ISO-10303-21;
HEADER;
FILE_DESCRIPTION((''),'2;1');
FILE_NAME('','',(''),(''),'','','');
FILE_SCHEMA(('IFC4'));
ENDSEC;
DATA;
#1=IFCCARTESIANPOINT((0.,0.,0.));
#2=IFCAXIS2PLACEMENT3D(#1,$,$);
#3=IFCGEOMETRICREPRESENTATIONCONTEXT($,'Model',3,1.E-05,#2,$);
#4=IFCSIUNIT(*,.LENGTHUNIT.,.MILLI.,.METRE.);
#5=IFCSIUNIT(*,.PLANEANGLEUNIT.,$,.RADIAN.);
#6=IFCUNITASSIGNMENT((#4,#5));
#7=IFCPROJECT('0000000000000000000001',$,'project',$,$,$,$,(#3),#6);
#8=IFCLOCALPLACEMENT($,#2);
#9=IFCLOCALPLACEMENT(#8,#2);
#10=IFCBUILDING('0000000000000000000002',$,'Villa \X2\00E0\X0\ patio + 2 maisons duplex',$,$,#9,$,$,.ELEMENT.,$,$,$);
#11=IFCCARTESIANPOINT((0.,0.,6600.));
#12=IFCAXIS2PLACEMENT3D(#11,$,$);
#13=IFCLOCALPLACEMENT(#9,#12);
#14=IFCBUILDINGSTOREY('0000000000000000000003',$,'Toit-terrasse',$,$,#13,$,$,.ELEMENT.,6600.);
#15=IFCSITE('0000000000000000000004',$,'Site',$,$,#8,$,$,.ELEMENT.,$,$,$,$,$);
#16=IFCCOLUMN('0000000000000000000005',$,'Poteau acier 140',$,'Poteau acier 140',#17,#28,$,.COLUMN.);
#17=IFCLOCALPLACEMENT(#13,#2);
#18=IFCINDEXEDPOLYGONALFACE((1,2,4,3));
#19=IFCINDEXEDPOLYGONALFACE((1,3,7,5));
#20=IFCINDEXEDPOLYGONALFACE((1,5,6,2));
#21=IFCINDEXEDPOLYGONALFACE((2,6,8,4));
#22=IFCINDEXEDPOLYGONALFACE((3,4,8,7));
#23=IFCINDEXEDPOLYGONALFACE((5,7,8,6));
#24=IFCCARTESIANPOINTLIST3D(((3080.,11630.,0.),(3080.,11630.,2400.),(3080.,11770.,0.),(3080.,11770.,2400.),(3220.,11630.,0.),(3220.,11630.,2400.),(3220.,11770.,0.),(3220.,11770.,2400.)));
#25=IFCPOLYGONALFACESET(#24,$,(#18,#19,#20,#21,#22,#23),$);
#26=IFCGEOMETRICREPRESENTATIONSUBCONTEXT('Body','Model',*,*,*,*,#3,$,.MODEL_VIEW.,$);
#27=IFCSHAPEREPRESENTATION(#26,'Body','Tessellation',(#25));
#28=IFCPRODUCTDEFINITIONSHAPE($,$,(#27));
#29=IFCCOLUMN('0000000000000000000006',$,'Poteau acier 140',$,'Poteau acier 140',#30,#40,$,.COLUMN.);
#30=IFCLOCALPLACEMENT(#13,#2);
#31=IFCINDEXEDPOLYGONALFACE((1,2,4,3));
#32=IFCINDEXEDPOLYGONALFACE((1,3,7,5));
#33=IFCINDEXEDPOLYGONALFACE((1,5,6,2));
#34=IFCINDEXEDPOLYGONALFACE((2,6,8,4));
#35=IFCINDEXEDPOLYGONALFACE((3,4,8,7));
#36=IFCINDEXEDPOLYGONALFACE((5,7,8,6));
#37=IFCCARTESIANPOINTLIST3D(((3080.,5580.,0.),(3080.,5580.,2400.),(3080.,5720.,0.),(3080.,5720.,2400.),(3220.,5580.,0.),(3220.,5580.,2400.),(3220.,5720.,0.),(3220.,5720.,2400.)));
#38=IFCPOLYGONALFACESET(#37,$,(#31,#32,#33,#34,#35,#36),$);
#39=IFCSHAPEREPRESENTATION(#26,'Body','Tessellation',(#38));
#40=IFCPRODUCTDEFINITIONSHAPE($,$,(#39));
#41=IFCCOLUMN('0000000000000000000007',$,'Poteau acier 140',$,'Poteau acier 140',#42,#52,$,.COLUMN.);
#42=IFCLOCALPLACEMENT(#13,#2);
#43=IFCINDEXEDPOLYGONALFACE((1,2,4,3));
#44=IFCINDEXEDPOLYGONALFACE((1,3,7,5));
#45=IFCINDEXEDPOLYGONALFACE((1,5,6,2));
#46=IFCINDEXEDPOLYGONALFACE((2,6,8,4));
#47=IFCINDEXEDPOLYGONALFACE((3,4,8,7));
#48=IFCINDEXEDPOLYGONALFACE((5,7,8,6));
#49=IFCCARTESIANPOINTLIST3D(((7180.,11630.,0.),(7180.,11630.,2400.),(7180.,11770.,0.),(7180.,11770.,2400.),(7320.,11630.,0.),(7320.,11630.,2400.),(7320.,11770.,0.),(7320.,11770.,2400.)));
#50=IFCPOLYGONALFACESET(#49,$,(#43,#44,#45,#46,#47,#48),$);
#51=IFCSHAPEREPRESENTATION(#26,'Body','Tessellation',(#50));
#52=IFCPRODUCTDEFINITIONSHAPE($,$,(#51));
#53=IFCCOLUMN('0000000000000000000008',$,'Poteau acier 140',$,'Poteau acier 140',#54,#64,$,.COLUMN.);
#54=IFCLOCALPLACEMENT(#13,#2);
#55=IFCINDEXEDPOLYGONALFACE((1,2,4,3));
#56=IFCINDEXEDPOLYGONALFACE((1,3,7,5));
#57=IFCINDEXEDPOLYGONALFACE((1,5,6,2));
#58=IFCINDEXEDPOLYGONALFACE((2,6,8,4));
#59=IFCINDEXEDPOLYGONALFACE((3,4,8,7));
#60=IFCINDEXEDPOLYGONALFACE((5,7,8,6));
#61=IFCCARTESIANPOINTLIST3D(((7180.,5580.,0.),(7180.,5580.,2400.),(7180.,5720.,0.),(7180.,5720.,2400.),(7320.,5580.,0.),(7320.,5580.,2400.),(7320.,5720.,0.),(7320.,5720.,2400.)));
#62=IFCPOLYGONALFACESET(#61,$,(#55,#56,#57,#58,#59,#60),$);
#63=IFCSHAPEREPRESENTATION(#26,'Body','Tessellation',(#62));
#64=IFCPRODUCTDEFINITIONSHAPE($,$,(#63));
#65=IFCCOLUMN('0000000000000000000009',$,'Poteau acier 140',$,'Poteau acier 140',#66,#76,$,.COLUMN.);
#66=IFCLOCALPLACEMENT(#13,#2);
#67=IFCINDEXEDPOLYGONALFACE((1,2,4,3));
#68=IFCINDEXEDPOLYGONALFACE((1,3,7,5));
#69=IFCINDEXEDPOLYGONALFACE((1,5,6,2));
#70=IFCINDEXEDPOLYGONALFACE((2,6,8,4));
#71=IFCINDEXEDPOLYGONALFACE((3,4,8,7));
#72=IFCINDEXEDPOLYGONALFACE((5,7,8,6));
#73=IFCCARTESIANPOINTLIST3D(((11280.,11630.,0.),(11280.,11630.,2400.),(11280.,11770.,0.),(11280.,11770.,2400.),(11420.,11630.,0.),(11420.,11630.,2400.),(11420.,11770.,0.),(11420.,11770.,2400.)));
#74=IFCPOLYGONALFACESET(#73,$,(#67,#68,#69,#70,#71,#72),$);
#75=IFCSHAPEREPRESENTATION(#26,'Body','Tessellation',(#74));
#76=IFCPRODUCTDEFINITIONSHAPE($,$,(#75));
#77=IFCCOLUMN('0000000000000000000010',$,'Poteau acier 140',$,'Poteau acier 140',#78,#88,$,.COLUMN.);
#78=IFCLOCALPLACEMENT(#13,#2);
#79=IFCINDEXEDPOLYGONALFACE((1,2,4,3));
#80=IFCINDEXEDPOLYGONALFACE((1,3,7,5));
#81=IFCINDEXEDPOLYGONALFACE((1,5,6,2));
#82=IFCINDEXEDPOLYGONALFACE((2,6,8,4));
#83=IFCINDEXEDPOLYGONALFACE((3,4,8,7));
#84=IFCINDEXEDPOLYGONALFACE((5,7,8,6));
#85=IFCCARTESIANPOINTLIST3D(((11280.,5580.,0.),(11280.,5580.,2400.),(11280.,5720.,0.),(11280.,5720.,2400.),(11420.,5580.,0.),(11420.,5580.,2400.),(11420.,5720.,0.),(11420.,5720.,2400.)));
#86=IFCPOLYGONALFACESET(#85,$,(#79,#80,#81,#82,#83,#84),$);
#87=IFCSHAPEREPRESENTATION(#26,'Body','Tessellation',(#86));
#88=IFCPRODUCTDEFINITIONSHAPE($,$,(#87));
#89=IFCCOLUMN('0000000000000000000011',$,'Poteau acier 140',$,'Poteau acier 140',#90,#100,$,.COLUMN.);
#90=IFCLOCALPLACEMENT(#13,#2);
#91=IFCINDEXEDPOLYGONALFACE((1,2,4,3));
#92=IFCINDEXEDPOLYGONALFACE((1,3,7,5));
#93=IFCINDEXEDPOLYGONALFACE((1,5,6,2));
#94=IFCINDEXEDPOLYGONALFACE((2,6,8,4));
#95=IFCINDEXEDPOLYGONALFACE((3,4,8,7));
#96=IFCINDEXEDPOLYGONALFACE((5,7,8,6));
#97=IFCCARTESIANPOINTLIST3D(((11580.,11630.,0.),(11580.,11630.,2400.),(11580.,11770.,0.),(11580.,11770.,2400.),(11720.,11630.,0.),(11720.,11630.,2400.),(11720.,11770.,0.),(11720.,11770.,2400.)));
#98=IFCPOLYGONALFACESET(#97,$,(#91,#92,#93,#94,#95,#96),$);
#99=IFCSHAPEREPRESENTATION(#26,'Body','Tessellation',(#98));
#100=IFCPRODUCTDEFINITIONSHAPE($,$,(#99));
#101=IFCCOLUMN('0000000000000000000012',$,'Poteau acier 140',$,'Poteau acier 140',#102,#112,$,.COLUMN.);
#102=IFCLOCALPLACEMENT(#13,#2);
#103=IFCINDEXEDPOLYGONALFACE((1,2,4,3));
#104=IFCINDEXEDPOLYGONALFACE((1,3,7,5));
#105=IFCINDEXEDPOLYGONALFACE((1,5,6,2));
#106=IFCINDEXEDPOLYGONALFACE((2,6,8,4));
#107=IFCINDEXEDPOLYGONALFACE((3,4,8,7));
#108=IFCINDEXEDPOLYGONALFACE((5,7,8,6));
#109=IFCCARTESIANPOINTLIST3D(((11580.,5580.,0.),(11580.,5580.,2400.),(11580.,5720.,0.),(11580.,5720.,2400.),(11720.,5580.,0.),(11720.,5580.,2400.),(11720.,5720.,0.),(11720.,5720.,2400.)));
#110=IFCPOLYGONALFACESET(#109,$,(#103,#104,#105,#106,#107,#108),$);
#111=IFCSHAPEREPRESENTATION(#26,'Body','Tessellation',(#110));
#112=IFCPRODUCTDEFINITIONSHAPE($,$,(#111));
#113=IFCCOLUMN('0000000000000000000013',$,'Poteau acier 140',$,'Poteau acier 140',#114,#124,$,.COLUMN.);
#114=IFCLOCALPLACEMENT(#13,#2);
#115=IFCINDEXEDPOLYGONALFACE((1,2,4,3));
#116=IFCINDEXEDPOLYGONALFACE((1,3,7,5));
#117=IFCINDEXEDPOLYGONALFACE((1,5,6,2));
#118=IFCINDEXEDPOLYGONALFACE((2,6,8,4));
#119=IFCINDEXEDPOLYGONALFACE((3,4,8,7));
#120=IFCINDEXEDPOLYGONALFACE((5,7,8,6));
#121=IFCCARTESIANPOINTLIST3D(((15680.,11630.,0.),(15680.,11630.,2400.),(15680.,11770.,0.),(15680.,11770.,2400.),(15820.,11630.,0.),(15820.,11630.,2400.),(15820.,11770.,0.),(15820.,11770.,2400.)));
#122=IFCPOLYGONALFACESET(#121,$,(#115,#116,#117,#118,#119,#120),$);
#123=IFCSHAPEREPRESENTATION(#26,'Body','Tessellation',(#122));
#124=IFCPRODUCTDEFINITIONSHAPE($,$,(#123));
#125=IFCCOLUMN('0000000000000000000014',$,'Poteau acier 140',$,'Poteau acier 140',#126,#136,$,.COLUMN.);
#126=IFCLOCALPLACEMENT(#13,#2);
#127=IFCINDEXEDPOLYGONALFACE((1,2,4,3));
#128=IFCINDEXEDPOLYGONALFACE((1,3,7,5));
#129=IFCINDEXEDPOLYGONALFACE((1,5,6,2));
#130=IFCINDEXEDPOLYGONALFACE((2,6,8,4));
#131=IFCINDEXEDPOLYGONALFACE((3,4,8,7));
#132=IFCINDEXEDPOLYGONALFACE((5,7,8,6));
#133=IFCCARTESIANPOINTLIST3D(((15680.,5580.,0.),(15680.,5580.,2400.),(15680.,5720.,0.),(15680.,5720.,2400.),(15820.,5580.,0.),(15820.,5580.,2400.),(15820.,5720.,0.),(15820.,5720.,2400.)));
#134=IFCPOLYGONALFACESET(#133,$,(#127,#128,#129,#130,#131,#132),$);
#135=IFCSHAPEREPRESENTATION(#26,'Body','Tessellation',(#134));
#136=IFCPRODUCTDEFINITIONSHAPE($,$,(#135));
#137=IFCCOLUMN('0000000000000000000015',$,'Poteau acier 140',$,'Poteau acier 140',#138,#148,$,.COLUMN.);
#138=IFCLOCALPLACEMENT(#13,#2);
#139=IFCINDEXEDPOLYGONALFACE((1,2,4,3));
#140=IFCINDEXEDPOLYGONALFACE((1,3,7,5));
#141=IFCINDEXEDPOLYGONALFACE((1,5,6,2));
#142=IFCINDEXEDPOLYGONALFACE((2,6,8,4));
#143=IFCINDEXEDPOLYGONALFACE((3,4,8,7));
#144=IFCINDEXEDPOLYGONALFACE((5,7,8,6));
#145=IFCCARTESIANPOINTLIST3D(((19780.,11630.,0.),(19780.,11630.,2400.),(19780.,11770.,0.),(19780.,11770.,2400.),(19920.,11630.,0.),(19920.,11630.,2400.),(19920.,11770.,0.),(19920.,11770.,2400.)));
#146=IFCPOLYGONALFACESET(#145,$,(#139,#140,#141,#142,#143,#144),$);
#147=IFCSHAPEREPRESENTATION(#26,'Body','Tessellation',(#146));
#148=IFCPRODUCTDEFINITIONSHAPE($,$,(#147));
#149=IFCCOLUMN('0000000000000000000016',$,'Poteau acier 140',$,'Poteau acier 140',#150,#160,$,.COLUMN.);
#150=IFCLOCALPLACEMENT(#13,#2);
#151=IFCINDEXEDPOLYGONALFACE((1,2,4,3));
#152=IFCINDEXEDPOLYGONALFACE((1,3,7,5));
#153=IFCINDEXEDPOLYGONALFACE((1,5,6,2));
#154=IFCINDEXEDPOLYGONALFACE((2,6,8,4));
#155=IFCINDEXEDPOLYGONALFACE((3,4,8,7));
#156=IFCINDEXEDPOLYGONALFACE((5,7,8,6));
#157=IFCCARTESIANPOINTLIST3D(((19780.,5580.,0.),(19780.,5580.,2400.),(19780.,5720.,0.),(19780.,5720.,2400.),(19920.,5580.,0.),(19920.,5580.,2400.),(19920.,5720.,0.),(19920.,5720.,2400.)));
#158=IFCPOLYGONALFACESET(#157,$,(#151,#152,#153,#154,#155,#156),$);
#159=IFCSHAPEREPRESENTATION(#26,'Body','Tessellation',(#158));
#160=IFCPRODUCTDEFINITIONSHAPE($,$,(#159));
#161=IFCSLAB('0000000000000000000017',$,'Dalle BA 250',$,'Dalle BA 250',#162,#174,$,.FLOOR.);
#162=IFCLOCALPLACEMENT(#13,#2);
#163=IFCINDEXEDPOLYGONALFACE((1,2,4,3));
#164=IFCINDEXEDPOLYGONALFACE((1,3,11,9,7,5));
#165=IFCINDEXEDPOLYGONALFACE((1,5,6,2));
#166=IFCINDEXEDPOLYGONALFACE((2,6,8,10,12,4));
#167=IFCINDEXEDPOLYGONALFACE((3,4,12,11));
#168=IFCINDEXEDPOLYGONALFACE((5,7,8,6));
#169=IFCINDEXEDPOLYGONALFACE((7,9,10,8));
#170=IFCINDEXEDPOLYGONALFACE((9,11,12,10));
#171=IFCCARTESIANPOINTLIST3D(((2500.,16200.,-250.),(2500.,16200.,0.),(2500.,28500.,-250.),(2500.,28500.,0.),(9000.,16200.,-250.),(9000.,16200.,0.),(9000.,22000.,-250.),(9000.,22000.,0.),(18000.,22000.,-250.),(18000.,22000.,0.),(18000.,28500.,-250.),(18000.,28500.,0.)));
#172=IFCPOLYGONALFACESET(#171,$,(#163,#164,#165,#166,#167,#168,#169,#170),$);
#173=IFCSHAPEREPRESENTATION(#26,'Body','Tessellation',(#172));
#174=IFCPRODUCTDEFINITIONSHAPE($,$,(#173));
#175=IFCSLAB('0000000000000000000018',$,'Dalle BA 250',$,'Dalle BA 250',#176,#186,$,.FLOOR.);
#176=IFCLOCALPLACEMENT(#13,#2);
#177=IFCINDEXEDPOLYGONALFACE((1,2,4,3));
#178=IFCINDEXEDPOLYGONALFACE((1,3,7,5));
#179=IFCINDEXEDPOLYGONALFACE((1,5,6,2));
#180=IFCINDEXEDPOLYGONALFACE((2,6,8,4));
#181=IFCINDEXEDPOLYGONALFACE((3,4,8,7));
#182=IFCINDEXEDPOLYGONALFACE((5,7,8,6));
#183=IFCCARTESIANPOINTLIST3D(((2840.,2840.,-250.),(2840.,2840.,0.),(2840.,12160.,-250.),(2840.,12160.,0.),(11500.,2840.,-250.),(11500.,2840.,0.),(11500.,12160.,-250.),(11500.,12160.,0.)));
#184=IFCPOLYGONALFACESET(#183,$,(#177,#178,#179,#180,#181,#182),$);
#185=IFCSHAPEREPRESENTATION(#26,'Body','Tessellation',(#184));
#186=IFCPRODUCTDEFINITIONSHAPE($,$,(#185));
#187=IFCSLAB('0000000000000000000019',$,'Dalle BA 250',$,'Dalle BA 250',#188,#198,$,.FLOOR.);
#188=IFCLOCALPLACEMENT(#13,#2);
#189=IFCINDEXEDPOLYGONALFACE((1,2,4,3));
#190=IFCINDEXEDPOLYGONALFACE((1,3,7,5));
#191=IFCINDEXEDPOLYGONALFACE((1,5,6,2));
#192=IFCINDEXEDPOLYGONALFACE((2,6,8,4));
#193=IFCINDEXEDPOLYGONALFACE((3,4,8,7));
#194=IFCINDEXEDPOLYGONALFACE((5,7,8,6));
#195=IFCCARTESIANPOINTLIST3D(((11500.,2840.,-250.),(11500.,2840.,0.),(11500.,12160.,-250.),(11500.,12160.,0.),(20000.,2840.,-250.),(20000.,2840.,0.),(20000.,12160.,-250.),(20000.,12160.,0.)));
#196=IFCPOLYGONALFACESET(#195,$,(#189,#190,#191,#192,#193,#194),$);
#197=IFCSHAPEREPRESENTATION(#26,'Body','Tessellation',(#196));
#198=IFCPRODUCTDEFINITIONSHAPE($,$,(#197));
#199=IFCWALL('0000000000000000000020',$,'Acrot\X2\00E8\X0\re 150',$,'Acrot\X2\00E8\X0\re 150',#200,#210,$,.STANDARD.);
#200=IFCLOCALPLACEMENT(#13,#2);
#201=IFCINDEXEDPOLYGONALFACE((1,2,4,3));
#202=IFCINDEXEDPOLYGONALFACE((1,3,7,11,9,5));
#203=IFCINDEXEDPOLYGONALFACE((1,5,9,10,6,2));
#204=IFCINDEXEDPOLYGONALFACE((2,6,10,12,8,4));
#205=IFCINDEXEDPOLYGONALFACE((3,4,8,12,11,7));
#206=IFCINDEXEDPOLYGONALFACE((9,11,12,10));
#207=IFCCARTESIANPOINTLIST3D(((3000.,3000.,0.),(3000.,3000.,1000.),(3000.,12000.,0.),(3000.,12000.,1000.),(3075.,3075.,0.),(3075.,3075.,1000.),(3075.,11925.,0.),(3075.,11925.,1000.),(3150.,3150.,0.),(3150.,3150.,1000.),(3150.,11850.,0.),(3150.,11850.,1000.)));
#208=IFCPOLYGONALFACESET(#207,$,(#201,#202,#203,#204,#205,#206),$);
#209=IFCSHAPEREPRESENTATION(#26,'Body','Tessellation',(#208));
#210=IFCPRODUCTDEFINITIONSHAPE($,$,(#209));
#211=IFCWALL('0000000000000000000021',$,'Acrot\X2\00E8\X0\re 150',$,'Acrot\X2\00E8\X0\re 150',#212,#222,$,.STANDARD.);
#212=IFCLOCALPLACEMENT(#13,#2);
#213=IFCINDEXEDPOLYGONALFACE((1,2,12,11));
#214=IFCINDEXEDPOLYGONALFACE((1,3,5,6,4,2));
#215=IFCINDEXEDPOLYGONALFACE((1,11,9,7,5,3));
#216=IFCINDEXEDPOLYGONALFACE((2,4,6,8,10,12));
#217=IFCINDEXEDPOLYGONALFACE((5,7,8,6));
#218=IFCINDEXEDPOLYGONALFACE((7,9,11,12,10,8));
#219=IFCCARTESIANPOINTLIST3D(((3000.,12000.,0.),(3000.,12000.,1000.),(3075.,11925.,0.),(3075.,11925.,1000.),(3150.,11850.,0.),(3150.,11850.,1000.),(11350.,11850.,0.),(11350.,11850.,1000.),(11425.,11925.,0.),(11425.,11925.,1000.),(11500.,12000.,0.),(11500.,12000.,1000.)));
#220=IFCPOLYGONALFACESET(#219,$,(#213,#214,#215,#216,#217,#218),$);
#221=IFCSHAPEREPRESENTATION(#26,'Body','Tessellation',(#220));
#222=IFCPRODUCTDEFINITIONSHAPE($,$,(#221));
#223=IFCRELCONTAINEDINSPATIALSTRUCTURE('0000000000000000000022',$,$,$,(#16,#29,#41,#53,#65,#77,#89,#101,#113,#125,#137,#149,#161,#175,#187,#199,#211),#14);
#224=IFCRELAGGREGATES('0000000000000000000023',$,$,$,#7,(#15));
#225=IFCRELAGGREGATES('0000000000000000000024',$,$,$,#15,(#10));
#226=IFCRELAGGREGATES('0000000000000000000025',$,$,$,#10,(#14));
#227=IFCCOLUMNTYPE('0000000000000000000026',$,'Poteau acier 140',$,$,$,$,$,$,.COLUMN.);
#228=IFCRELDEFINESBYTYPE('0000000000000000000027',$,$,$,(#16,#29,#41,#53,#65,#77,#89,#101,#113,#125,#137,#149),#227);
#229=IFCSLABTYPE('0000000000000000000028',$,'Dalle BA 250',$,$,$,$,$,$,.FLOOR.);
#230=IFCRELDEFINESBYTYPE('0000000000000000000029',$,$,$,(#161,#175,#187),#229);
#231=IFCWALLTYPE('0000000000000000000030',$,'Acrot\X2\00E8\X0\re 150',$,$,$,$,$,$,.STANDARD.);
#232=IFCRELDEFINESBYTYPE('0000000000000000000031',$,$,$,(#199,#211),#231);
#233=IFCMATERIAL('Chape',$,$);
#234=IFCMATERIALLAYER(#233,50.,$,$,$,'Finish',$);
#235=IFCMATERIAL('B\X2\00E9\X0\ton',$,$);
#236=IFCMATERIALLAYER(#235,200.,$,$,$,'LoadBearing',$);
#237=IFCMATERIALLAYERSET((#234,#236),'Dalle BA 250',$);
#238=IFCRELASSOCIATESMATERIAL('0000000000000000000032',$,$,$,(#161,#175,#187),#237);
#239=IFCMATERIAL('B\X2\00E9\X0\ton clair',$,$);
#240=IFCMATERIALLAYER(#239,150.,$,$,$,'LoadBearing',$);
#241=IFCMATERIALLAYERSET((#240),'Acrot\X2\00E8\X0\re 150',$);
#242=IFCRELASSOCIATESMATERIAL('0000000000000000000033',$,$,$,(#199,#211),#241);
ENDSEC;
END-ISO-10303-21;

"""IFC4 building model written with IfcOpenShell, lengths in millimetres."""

from ifc_helpers import new_model, si_unit, frame, origin, origin_2d, place, context, subcontext, project, spatial, polyline, rectangle, outline, extrude, material, layer, layer_set, layer_usage, material_profile, profile_set, profile_usage, type_object, element, save


model = new_model("IFC4")

# Units and contexts
model_context = context("Model", 3, precision=1e-05, world=origin())
body_context = subcontext(model_context, "Body", "Model", "MODEL_VIEW")
ifc_project = project(units=[si_unit("LENGTHUNIT", "METRE", prefix="MILLI"), si_unit("PLANEANGLEUNIT", "RADIAN")], contexts=[model_context])

# Site, building, storey
site_placement = place(None, origin())
site = spatial("IfcSite", under=ifc_project, at=site_placement, Name="Site", CompositionType="ELEMENT")
building_placement = place(site_placement, origin())
building = spatial("IfcBuilding", under=site, at=building_placement, Name="Villa à patio + 2 maisons duplex", CompositionType="ELEMENT")
storey_placement = place(building_placement, frame((0.0, 0.0, 6600.0)))
storey = spatial("IfcBuildingStorey", under=building, at=storey_placement, Name="Toit-terrasse", CompositionType="ELEMENT", Elevation=6600.0)

# Columns
ifc_material_profile = material_profile(None, rectangle(XDim=140.0, YDim=140.0, at=origin_2d()), Name="Poteau acier 140")
ifc_profile_set = profile_set([ifc_material_profile], Name="Poteau acier 140")
ifc_profile_usage = profile_usage(ifc_profile_set, cardinal=5)
column_type = type_object("IfcColumnType", Name="Poteau acier 140", PredefinedType="COLUMN", material=ifc_profile_set)
for number, where, z_axis, x_axis, name in (
    (1, (3150.0, 11700.0, 0.0), (0.0, 0.0, 1.0), (1.0, 0.0, 0.0), "Poteau acier 140"),
    (2, (3150.0, 5650.0, 0.0), (0.0, 0.0, 1.0), (1.0, 0.0, 0.0), "Poteau acier 140"),
    (3, (7250.0, 11700.0, 0.0), (0.0, 0.0, 1.0), (1.0, 0.0, 0.0), "Poteau acier 140"),
    (4, (7250.0, 5650.0, 0.0), (0.0, 0.0, 1.0), (1.0, 0.0, 0.0), "Poteau acier 140"),
    (5, (11350.0, 11700.0, 0.0), (0.0, 0.0, 1.0), (1.0, 0.0, 0.0), "Poteau acier 140"),
    (6, (11350.0, 5650.0, 0.0), (0.0, 0.0, 1.0), (1.0, 0.0, 0.0), "Poteau acier 140"),
    (7, (11650.0, 11700.0, 0.0), (0.0, 0.0, 1.0), (1.0, 0.0, 0.0), "Poteau acier 140"),
    (8, (11650.0, 5650.0, 0.0), (0.0, 0.0, 1.0), (1.0, 0.0, 0.0), "Poteau acier 140"),
    (9, (15750.0, 11700.0, 0.0), (0.0, 0.0, 1.0), (1.0, 0.0, 0.0), "Poteau acier 140"),
    (10, (15750.0, 5650.0, 0.0), (0.0, 0.0, 1.0), (1.0, 0.0, 0.0), "Poteau acier 140"),
    (11, (19850.0, 11700.0, 0.0), (0.0, 0.0, 1.0), (1.0, 0.0, 0.0), "Poteau acier 140"),
    (12, (19850.0, 5650.0, 0.0), (0.0, 0.0, 1.0), (1.0, 0.0, 0.0), "Poteau acier 140"),
):
    element("IfcColumn", number, at=place(storey_placement, frame(where, z_axis=z_axis, x_axis=x_axis)), inside=storey, type_object=column_type, material=ifc_profile_usage, Name=name, ObjectType="Poteau acier 140", PredefinedType="COLUMN", context=body_context, shape_type="SweptSolid", body=[
        extrude(rectangle(XDim=140.0, YDim=140.0, at=origin_2d()), origin(), (0.0, 0.0, 1.0), 2400.0),
    ])

# Slabs
ifc_material_1 = material(Name="Chape")
ifc_layer_1 = layer(ifc_material_1, 50.0, Category="Finish")
ifc_material_2 = material(Name="Béton")
ifc_layer_2 = layer(ifc_material_2, 200.0, Category="LoadBearing")
ifc_layer_set_1 = layer_set([ifc_layer_1, ifc_layer_2], Name="Dalle BA 250")
ifc_layer_usage_1 = layer_usage(ifc_layer_set_1, "AXIS3", "NEGATIVE", 0.0)
slab_type = type_object("IfcSlabType", Name="Dalle BA 250", PredefinedType="FLOOR")
slab_1_placement = place(storey_placement, origin())
element("IfcSlab", 13, at=slab_1_placement, inside=storey, type_object=slab_type, material=ifc_layer_usage_1, Name="Dalle BA 250", ObjectType="Dalle BA 250", PredefinedType="FLOOR", context=body_context, shape_type="SweptSolid", body=[
    extrude(outline(polyline([(18000.0, 28500.0), (2500.0, 28500.0), (2500.0, 16200.0), (9000.0, 16200.0), (9000.0, 22000.0), (18000.0, 22000.0), (18000.0, 28500.0)])), frame((0.0, 0.0, -250.0)), (0.0, 0.0, 1.0), 250.0),
])
slab_2_placement = place(storey_placement, origin())
element("IfcSlab", 14, at=slab_2_placement, inside=storey, type_object=slab_type, material=ifc_layer_usage_1, Name="Dalle BA 250", ObjectType="Dalle BA 250", PredefinedType="FLOOR", context=body_context, shape_type="SweptSolid", body=[
    extrude(outline(polyline([(2840.0, 12160.0), (2840.0, 2840.0), (11500.0, 2840.0), (11500.0, 12160.0), (2840.0, 12160.0)])), frame((0.0, 0.0, -250.0)), (0.0, 0.0, 1.0), 250.0),
])
slab_3_placement = place(storey_placement, origin())
element("IfcSlab", 15, at=slab_3_placement, inside=storey, type_object=slab_type, material=ifc_layer_usage_1, Name="Dalle BA 250", ObjectType="Dalle BA 250", PredefinedType="FLOOR", context=body_context, shape_type="SweptSolid", body=[
    extrude(outline(polyline([(11500.0, 12160.0), (11500.0, 2840.0), (20000.0, 2840.0), (20000.0, 12160.0), (11500.0, 12160.0)])), frame((0.0, 0.0, -250.0)), (0.0, 0.0, 1.0), 250.0),
])

# Walls
ifc_material_3 = material(Name="Béton clair")
ifc_layer_3 = layer(ifc_material_3, 150.0, Category="LoadBearing")
ifc_layer_set_2 = layer_set([ifc_layer_3], Name="Acrotère 150")
ifc_layer_usage_2 = layer_usage(ifc_layer_set_2, "AXIS2", "NEGATIVE", 75.0)
wall_type_1 = type_object("IfcWallType", Name="Acrotère 150", PredefinedType="STANDARD")
wall_1_placement = place(storey_placement, frame((3075.0, 3075.0, 0.0), z_axis=(0.0, 0.0, 1.0), x_axis=(0.0, 1.0, 0.0)))
element("IfcWall", 16, at=wall_1_placement, inside=storey, type_object=wall_type_1, material=ifc_layer_usage_2, Name="Acrotère 150", ObjectType="Acrotère 150", PredefinedType="STANDARD", context=body_context, shape_type="SweptSolid", body=[
    extrude(outline(polyline([(75.0, -75.0), (0.0, 0.0), (-75.0, 75.0), (8925.0, 75.0), (8850.0, 0.0), (8775.0, -75.0), (75.0, -75.0)])), origin(), (0.0, 0.0, 1.0), 1000.0),
])
wall_2_placement = place(storey_placement, frame((3075.0, 11925.0, 0.0), z_axis=(0.0, 0.0, 1.0), x_axis=(1.0, 0.0, 0.0)))
element("IfcWall", 17, at=wall_2_placement, inside=storey, type_object=wall_type_1, material=ifc_layer_usage_2, Name="Acrotère 150", ObjectType="Acrotère 150", PredefinedType="STANDARD", context=body_context, shape_type="SweptSolid", body=[
    extrude(outline(polyline([(75.0, -75.0), (0.0, 0.0), (-75.0, 75.0), (8425.0, 75.0), (8350.0, 0.0), (8275.0, -75.0), (75.0, -75.0)])), origin(), (0.0, 0.0, 1.0), 1000.0),
])

save(model, "model.ifc")
